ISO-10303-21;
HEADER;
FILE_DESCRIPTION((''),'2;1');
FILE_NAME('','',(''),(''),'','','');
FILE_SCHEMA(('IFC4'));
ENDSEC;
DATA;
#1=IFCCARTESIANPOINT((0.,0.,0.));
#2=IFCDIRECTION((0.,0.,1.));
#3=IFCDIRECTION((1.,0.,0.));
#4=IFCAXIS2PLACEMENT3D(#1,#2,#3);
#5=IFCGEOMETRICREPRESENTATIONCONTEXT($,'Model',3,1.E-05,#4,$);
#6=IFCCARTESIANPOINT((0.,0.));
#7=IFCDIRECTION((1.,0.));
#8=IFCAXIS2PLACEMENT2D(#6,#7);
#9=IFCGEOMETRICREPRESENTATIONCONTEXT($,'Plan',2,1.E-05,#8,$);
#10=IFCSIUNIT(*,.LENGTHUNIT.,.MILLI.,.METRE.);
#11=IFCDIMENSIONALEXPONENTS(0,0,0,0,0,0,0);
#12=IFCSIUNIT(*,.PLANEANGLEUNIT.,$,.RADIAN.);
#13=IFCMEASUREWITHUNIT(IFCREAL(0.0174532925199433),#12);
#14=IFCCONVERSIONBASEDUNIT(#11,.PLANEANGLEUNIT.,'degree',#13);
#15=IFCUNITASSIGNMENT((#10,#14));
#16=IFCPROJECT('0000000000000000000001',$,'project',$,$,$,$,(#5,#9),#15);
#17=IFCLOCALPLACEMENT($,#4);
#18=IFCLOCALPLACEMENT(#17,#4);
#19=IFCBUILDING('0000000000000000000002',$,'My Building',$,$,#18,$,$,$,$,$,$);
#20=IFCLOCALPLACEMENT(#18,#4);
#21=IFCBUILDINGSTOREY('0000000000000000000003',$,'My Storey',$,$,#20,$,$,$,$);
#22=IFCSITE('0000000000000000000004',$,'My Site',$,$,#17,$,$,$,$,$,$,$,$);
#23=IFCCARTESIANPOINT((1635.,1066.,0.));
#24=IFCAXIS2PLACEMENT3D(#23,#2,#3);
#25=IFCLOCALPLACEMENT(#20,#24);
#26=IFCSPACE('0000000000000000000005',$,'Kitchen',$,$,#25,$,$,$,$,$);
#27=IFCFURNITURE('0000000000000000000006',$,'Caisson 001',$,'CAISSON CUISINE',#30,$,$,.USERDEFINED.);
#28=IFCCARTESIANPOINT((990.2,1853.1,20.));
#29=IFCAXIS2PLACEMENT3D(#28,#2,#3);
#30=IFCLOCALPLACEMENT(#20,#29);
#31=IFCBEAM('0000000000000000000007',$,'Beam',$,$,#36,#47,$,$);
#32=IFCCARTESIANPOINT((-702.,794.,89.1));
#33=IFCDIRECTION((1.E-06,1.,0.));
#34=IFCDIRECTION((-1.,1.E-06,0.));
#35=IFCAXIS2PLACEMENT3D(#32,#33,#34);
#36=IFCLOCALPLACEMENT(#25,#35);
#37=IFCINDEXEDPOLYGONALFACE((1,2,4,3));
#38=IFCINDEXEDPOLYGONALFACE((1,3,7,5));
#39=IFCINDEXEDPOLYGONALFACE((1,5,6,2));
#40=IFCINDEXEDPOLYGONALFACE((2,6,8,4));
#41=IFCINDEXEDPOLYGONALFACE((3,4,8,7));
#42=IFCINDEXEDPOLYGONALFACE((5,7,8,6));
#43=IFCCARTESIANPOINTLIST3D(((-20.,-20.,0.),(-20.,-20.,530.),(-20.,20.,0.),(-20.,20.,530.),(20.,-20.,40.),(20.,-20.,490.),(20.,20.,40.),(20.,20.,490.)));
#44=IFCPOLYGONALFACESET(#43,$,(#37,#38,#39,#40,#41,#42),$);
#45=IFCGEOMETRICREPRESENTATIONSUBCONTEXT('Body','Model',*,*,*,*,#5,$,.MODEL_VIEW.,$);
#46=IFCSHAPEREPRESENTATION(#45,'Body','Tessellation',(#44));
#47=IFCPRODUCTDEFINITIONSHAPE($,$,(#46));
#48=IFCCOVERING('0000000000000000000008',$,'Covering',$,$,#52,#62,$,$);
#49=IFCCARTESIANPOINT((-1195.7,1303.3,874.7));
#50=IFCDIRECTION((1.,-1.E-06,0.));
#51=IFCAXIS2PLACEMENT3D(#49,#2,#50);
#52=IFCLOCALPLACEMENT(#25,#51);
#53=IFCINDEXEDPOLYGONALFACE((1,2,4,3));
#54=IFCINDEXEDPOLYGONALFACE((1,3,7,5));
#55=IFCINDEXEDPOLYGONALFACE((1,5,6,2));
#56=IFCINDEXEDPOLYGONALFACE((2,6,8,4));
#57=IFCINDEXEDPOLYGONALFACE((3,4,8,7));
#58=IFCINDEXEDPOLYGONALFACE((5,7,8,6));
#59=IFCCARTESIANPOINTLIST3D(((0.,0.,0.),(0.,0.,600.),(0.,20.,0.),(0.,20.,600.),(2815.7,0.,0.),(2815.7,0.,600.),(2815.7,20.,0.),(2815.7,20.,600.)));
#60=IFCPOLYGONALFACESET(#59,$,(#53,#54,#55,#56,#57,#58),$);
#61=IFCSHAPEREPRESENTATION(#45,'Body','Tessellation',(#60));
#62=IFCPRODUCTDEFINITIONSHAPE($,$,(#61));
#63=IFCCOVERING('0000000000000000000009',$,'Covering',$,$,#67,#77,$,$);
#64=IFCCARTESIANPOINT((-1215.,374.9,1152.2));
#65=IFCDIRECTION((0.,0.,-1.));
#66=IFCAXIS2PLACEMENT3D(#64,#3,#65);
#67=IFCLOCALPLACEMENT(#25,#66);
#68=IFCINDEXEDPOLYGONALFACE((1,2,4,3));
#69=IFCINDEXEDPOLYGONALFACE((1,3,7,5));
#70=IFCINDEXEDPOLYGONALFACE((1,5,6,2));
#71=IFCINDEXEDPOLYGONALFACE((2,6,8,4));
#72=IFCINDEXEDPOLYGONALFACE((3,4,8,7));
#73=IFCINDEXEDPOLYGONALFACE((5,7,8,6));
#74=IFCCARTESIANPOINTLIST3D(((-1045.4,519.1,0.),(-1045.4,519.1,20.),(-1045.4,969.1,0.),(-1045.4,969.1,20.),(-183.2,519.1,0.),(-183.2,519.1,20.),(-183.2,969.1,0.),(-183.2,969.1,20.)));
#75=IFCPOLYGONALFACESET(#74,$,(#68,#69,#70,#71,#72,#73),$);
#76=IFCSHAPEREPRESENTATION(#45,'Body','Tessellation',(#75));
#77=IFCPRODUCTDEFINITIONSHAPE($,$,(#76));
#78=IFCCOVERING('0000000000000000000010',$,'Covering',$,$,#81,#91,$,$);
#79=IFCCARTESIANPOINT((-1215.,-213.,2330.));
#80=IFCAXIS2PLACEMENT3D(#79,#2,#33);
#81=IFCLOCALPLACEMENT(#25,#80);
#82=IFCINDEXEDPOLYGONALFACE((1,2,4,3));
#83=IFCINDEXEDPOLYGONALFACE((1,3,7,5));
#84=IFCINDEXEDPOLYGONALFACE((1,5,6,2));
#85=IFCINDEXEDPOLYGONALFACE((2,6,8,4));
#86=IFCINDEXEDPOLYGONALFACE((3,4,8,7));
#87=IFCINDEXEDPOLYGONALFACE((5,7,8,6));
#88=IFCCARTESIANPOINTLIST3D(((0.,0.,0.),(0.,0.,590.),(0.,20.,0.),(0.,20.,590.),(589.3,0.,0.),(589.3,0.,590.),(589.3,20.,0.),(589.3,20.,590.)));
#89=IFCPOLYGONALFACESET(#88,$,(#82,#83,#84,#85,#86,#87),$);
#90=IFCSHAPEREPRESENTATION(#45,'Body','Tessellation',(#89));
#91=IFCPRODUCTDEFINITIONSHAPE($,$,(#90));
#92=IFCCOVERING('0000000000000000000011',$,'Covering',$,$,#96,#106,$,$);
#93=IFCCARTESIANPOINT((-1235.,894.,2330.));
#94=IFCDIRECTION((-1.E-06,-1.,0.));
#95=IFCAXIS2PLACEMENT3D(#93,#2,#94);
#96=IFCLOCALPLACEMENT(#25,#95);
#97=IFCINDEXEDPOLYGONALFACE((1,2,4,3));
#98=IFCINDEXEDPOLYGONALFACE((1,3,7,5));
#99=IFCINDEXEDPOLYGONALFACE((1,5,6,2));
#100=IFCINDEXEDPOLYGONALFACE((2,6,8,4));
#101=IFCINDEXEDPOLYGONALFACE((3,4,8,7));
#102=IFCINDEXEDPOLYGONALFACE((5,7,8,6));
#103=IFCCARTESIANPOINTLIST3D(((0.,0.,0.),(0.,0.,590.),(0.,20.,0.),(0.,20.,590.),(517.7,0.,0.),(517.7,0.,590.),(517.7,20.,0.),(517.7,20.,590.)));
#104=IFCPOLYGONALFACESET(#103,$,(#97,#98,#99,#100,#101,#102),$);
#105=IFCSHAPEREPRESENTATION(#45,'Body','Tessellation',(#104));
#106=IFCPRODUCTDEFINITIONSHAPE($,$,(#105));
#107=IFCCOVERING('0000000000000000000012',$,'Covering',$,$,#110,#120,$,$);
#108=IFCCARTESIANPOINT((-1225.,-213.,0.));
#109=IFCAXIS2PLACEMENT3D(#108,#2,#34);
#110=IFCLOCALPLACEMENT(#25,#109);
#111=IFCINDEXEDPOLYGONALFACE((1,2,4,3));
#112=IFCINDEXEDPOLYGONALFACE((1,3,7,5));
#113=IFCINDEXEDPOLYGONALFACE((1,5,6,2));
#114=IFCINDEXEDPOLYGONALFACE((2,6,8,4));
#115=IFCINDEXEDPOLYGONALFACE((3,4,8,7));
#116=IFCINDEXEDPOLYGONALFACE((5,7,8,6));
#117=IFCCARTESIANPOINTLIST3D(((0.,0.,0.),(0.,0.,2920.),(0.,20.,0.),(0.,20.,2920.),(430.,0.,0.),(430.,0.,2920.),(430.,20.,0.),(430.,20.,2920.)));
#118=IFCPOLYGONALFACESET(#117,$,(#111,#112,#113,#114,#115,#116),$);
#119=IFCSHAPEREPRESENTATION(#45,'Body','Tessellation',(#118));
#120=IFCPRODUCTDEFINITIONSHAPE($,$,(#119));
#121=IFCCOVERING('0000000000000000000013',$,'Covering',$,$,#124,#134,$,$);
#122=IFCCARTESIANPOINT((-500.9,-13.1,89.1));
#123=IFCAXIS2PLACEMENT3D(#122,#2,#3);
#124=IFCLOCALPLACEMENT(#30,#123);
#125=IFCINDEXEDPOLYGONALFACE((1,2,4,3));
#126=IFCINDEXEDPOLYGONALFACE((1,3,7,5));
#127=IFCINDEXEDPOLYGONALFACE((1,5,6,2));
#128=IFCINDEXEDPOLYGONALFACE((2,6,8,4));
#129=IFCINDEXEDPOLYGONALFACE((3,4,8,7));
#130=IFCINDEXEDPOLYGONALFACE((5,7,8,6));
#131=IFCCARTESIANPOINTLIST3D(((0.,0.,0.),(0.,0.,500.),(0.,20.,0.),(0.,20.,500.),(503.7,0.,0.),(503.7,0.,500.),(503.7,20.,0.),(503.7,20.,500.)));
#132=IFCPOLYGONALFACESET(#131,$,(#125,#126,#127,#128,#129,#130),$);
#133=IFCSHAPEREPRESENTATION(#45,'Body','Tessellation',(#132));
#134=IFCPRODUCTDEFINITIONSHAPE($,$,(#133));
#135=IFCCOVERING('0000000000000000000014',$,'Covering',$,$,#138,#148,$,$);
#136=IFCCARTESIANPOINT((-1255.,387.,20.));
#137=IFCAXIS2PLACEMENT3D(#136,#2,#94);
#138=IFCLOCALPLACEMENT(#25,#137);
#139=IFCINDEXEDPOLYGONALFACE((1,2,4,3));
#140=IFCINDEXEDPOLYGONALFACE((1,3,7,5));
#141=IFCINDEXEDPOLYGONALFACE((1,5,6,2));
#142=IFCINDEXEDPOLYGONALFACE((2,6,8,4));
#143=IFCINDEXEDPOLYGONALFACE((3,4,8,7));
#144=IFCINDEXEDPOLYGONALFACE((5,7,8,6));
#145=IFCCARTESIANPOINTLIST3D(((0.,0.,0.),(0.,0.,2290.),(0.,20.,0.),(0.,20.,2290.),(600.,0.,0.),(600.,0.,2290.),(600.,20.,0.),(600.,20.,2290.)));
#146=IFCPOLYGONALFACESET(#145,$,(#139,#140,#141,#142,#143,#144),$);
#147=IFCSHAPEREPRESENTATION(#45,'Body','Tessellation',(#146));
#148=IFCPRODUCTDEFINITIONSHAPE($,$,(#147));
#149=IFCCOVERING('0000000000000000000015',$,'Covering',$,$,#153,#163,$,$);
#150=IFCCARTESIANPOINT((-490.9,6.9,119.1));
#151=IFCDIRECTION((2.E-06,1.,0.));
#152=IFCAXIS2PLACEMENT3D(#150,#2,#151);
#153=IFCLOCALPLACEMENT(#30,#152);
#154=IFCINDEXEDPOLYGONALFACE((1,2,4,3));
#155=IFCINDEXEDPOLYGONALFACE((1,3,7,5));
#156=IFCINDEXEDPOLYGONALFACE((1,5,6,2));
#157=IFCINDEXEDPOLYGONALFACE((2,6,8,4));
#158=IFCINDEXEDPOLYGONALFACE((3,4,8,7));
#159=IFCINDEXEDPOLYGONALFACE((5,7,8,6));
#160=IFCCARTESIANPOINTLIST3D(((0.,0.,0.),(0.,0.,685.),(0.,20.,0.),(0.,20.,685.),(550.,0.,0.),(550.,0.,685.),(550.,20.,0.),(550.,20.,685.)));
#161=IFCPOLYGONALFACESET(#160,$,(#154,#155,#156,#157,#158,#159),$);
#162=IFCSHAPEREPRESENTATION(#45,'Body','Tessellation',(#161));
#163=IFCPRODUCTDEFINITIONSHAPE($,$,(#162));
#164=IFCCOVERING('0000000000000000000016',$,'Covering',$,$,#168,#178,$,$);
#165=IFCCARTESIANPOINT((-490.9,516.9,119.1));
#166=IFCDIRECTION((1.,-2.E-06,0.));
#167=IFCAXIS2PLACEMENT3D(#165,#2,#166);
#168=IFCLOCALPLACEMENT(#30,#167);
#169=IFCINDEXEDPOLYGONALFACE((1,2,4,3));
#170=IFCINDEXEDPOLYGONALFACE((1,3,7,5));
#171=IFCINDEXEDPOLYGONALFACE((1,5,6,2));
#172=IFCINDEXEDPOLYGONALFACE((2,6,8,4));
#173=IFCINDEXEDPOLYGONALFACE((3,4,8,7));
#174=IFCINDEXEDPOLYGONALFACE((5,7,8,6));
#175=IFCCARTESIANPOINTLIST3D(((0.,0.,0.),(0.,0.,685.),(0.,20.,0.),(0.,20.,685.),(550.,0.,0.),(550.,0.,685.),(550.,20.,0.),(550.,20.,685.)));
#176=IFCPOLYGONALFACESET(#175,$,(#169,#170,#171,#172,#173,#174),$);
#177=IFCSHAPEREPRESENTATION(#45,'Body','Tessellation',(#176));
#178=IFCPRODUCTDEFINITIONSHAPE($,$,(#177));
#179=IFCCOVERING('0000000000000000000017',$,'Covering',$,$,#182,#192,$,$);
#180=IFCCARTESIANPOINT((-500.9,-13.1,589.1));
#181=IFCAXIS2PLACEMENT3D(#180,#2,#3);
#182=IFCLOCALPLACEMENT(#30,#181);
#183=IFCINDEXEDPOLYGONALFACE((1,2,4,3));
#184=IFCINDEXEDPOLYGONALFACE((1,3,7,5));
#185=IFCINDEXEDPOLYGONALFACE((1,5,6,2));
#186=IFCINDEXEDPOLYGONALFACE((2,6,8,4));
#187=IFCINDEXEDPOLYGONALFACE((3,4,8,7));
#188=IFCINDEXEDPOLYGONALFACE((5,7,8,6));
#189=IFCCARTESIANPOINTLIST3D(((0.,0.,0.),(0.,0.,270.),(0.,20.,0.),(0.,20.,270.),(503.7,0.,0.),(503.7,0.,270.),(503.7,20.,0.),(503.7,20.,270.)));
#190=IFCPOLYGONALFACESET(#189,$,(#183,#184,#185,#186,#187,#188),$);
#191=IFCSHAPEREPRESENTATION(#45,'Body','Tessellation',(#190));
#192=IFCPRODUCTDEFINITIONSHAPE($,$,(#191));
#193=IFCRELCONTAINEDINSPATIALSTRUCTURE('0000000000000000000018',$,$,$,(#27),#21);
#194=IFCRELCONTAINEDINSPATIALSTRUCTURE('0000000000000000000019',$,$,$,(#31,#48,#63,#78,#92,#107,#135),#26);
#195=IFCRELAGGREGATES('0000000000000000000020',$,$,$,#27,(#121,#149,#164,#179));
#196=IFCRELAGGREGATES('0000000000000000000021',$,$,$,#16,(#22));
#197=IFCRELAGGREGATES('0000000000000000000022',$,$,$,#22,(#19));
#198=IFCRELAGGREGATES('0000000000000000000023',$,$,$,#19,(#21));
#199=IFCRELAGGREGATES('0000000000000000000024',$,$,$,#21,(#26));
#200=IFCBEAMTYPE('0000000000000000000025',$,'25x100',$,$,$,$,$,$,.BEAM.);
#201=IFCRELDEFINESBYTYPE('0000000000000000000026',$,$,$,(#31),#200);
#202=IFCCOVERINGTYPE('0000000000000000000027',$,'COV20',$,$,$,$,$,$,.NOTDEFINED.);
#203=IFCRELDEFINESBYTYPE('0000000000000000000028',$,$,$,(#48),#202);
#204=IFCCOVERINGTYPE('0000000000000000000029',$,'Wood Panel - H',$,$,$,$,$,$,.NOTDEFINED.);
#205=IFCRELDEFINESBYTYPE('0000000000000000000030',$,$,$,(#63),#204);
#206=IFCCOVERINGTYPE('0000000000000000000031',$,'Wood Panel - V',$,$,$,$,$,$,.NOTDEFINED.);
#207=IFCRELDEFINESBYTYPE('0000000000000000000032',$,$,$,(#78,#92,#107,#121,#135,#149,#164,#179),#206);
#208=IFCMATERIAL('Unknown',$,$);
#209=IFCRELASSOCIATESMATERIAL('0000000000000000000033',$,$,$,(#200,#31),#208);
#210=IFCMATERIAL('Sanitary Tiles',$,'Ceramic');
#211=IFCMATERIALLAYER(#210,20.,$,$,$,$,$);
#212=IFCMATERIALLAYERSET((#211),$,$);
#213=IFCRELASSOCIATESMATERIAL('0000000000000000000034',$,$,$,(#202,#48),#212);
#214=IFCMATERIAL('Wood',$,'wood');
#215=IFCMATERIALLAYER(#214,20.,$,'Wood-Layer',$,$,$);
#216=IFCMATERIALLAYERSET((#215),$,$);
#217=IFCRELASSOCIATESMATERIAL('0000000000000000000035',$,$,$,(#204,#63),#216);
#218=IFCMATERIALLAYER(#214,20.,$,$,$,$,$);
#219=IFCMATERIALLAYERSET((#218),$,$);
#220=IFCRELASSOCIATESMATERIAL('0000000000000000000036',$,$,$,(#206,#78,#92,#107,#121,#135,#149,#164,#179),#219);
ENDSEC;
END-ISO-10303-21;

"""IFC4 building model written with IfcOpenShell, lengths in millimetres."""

from ifc_helpers import new_model, entity, si_unit, converted_unit, frame, origin_with_axes, origin_2d_with_axis, place, context, subcontext, project, spatial, indexed_curve, rectangle, outline, extrude, clip, halfspace, material, layer, layer_set, layer_usage, material_profile, profile_set, profile_usage, type_object, element, aggregate, save


model = new_model("IFC4")

# Units and contexts
model_context = context("Model", 3, precision=1e-05, world=origin_with_axes())
plan_context = context("Plan", 2, precision=1e-05, world=origin_2d_with_axis())
body_context = subcontext(model_context, "Body", "Model", "MODEL_VIEW")
ifc_project = project(units=[si_unit("LENGTHUNIT", "METRE", prefix="MILLI"), converted_unit("PLANEANGLEUNIT", "degree", entity("IfcReal", 0.0174532925199433), si_unit("PLANEANGLEUNIT", "RADIAN"), dimensions=[0, 0, 0, 0, 0, 0, 0])], contexts=[model_context, plan_context])

# Site, building, storey, space
site_placement = place(None, origin_with_axes())
site = spatial("IfcSite", under=ifc_project, at=site_placement, Name="My Site")
building_placement = place(site_placement, origin_with_axes())
building = spatial("IfcBuilding", under=site, at=building_placement, Name="My Building")
storey_placement = place(building_placement, origin_with_axes())
storey = spatial("IfcBuildingStorey", under=building, at=storey_placement, Name="My Storey")
space_1_placement = place(storey_placement, frame((1635.0, 1066.0, 0.0), z_axis=(0.0, 0.0, 1.0), x_axis=(1.0, 0.0, 0.0)))
space_1 = spatial("IfcSpace", under=storey, at=space_1_placement, Name="Kitchen")

# Shared definitions
ifc_material_1 = material(Name="Unknown")
ifc_material_profile = material_profile(ifc_material_1, rectangle(XDim=40.0, YDim=40.0))
ifc_profile_set = profile_set([ifc_material_profile])
beam_type = type_object("IfcBeamType", Name="25x100", PredefinedType="BEAM", material=ifc_profile_set)

# Furniture
furniture_1_placement = place(storey_placement, frame((990.2, 1853.1, 20.0), z_axis=(0.0, 0.0, 1.0), x_axis=(1.0, 0.0, 0.0)))
furniture_1 = element("IfcFurniture", 1, at=furniture_1_placement, inside=storey, Name="Caisson 001", ObjectType="CAISSON CUISINE", PredefinedType="USERDEFINED")

# Beam
ifc_profile_usage_1 = profile_usage(ifc_profile_set, cardinal=5)
beam_1_placement = place(space_1_placement, frame((-702.0, 794.0, 89.1), z_axis=(0.000001, 1.0, 0.0), x_axis=(-1.0, 0.000001, 0.0)))
element("IfcBeam", 2, at=beam_1_placement, inside=space_1, type_object=beam_type, material=ifc_profile_usage_1, Name="Beam", context=body_context, shape_type="Clipping", body=[
    clip(clip(extrude(rectangle(XDim=40.0, YDim=40.0), origin_with_axes(), (0.0, 0.0, 1.0), 530.0), halfspace(frame((-20.0, -874.0, 530.0), z_axis=(0.707107, 0.0, 0.707106), x_axis=(0.0, -1.0, 0.0)), False)), halfspace(frame((-20.0, -874.0, 0.0), z_axis=(0.707111, 0.0, -0.707103), x_axis=(0.0, -1.0, 0.0)), False)),
])

# Coverings
ifc_material_2 = material(Name="Sanitary Tiles", Category="Ceramic")
ifc_layer_1 = layer(ifc_material_2, 20.0)
ifc_layer_set_1 = layer_set([ifc_layer_1])
covering_type_1 = type_object("IfcCoveringType", Name="COV20", PredefinedType="NOTDEFINED", material=ifc_layer_set_1)
ifc_layer_usage_1 = layer_usage(ifc_layer_set_1, "AXIS2", "POSITIVE", 0.0)
covering_1_placement = place(space_1_placement, frame((-1195.7, 1303.3, 874.7), z_axis=(0.0, 0.0, 1.0), x_axis=(1.0, -0.000001, 0.0)))
element("IfcCovering", 3, at=covering_1_placement, inside=space_1, type_object=covering_type_1, material=ifc_layer_usage_1, Name="Covering", context=body_context, shape_type="Clipping", body=[
    clip(extrude(outline(indexed_curve([(0.0, 0.0), (0.0, 20.0), (2815.7, 20.0), (2815.7, 0.0), (0.0, 0.0)], self_intersect=False)), origin_with_axes(), (0.0, 0.0, 1.0), 600.0), halfspace(frame((0.0, 0.0, 600.0), z_axis=(0.0, 0.0, 1.0), x_axis=(-1.0, 0.0, 0.0)), False)),
])
ifc_material_3 = material(Name="Wood", Category="wood")
ifc_layer_2 = layer(ifc_material_3, 20.0, Name="Wood-Layer")
ifc_layer_set_2 = layer_set([ifc_layer_2])
ifc_layer_usage_2 = layer_usage(ifc_layer_set_2, "AXIS3", "POSITIVE", 0.0)
covering_type_2 = type_object("IfcCoveringType", Name="Wood Panel - H", PredefinedType="NOTDEFINED", material=ifc_layer_set_2)
covering_2_placement = place(space_1_placement, frame((-1215.0, 374.9, 1152.2), z_axis=(1.0, 0.0, 0.0), x_axis=(0.0, 0.0, -1.0)))
element("IfcCovering", 4, at=covering_2_placement, inside=space_1, type_object=covering_type_2, material=ifc_layer_usage_2, Name="Covering", context=body_context, shape_type="SweptSolid", body=[
    extrude(outline(indexed_curve([(-1045.4, 519.1), (-1045.4, 969.1), (-183.2, 969.1), (-183.2, 519.1), (-1045.4, 519.1)])), None, (0.0, 0.0, 1.0), 20.0),
])
ifc_layer_3 = layer(ifc_material_3, 20.0)
ifc_layer_set_3 = layer_set([ifc_layer_3])
covering_type_3 = type_object("IfcCoveringType", Name="Wood Panel - V", PredefinedType="NOTDEFINED", material=ifc_layer_set_3)
ifc_layer_usage_3 = layer_usage(ifc_layer_set_3, "AXIS2", "POSITIVE", 0.0)
covering_3_placement = place(space_1_placement, frame((-1215.0, -213.0, 2330.0), z_axis=(0.0, 0.0, 1.0), x_axis=(0.000001, 1.0, 0.0)))
element("IfcCovering", 5, at=covering_3_placement, inside=space_1, type_object=covering_type_3, material=ifc_layer_usage_3, Name="Covering", context=body_context, shape_type="Clipping", body=[
    clip(extrude(outline(indexed_curve([(0.0, 0.0), (0.0, 20.0), (589.3, 20.0), (589.3, 0.0), (0.0, 0.0)], self_intersect=False)), origin_with_axes(), (0.0, 0.0, 1.0), 590.0), halfspace(frame((0.0, 0.0, 590.0), z_axis=(0.0, 0.0, 1.0), x_axis=(-1.0, 0.0, 0.0)), False)),
])
ifc_layer_usage_4 = layer_usage(ifc_layer_set_3, "AXIS2", "POSITIVE", 0.0)
covering_4_placement = place(space_1_placement, frame((-1235.0, 894.0, 2330.0), z_axis=(0.0, 0.0, 1.0), x_axis=(-0.000001, -1.0, 0.0)))
element("IfcCovering", 6, at=covering_4_placement, inside=space_1, type_object=covering_type_3, material=ifc_layer_usage_4, Name="Covering", context=body_context, shape_type="Clipping", body=[
    clip(extrude(outline(indexed_curve([(0.0, 0.0), (0.0, 20.0), (517.7, 20.0), (517.7, 0.0), (0.0, 0.0)], self_intersect=False)), origin_with_axes(), (0.0, 0.0, 1.0), 590.0), halfspace(frame((0.0, 0.0, 590.0), z_axis=(0.0, 0.0, 1.0), x_axis=(-1.0, 0.0, 0.0)), False)),
])
ifc_layer_usage_5 = layer_usage(ifc_layer_set_3, "AXIS2", "POSITIVE", 0.0)
covering_5_placement = place(space_1_placement, frame((-1225.0, -213.0, 0.0), z_axis=(0.0, 0.0, 1.0), x_axis=(-1.0, 0.000001, 0.0)))
element("IfcCovering", 7, at=covering_5_placement, inside=space_1, type_object=covering_type_3, material=ifc_layer_usage_5, Name="Covering", context=body_context, shape_type="Clipping", body=[
    clip(clip(extrude(outline(indexed_curve([(0.0, 0.0), (0.0, 20.0), (430.0, 20.0), (430.0, 0.0), (0.0, 0.0)], self_intersect=False)), origin_with_axes(), (0.0, 0.0, 1.0), 2920.0), halfspace(frame((0.0, 0.0, 2920.0), z_axis=(0.0, 0.0, 1.0), x_axis=(-1.0, 0.0, 0.0)), False)), halfspace(frame((0.0, 0.0, 2920.0), z_axis=(0.0, 0.0, 1.0), x_axis=(-1.0, 0.0, 0.0)), False)),
])

# Covering
ifc_layer_usage_6 = layer_usage(ifc_layer_set_3, "AXIS2", "POSITIVE", 0.0)
covering_6_placement = place(furniture_1_placement, frame((-500.9, -13.1, 89.1), z_axis=(0.0, 0.0, 1.0), x_axis=(1.0, 0.0, 0.0)))
covering_6 = element("IfcCovering", 8, at=covering_6_placement, type_object=covering_type_3, material=ifc_layer_usage_6, Name="Covering", context=body_context, shape_type="SweptSolid", body=[
    extrude(outline(indexed_curve([(0.0, 0.0), (0.0, 20.0), (503.7, 20.0), (503.7, 0.0), (0.0, 0.0)], self_intersect=False)), origin_with_axes(), (0.0, 0.0, 1.0), 500.0),
])

# Covering
ifc_layer_usage_7 = layer_usage(ifc_layer_set_3, "AXIS2", "POSITIVE", 0.0)
covering_7_placement = place(space_1_placement, frame((-1255.0, 387.0, 20.0), z_axis=(0.0, 0.0, 1.0), x_axis=(-0.000001, -1.0, 0.0)))
element("IfcCovering", 9, at=covering_7_placement, inside=space_1, type_object=covering_type_3, material=ifc_layer_usage_7, Name="Covering", context=body_context, shape_type="Clipping", body=[
    clip(extrude(outline(indexed_curve([(0.0, 0.0), (0.0, 20.0), (600.0, 20.0), (600.0, 0.0), (0.0, 0.0)], self_intersect=False)), origin_with_axes(), (0.0, 0.0, 1.0), 2290.0), halfspace(frame((0.0, 0.0, 2290.0), z_axis=(0.0, 0.0, 1.0), x_axis=(-1.0, 0.0, 0.0)), False)),
])

# Coverings
ifc_layer_usage_8 = layer_usage(ifc_layer_set_3, "AXIS2", "POSITIVE", 0.0)
covering_8_placement = place(furniture_1_placement, frame((-490.9, 6.9, 119.1), z_axis=(0.0, 0.0, 1.0), x_axis=(0.000002, 1.0, 0.0)))
covering_8 = element("IfcCovering", 10, at=covering_8_placement, type_object=covering_type_3, material=ifc_layer_usage_8, Name="Covering", context=body_context, shape_type="SweptSolid", body=[
    extrude(outline(indexed_curve([(0.0, 0.0), (0.0, 20.0), (550.0, 20.0), (550.0, 0.0), (0.0, 0.0)], self_intersect=False)), origin_with_axes(), (0.0, 0.0, 1.0), 685.0),
])
ifc_layer_usage_9 = layer_usage(ifc_layer_set_3, "AXIS2", "POSITIVE", 0.0)
covering_9_placement = place(furniture_1_placement, frame((-490.9, 516.9, 119.1), z_axis=(0.0, 0.0, 1.0), x_axis=(1.0, -0.000002, 0.0)))
covering_9 = element("IfcCovering", 11, at=covering_9_placement, type_object=covering_type_3, material=ifc_layer_usage_9, Name="Covering", context=body_context, shape_type="SweptSolid", body=[
    extrude(outline(indexed_curve([(0.0, 0.0), (0.0, 20.0), (550.0, 20.0), (550.0, 0.0), (0.0, 0.0)], self_intersect=False)), origin_with_axes(), (0.0, 0.0, 1.0), 685.0),
])
ifc_layer_usage_10 = layer_usage(ifc_layer_set_3, "AXIS2", "POSITIVE", 0.0)
covering_10_placement = place(furniture_1_placement, frame((-500.9, -13.1, 589.1), z_axis=(0.0, 0.0, 1.0), x_axis=(1.0, 0.0, 0.0)))
covering_10 = element("IfcCovering", 12, at=covering_10_placement, type_object=covering_type_3, material=ifc_layer_usage_10, Name="Covering", context=body_context, shape_type="SweptSolid", body=[
    extrude(outline(indexed_curve([(0.0, 0.0), (0.0, 20.0), (503.7, 20.0), (503.7, 0.0), (0.0, 0.0)], self_intersect=False)), origin_with_axes(), (0.0, 0.0, 1.0), 270.0),
])

aggregate(furniture_1, [covering_6, covering_8, covering_9, covering_10])

save(model, "model.ifc")
